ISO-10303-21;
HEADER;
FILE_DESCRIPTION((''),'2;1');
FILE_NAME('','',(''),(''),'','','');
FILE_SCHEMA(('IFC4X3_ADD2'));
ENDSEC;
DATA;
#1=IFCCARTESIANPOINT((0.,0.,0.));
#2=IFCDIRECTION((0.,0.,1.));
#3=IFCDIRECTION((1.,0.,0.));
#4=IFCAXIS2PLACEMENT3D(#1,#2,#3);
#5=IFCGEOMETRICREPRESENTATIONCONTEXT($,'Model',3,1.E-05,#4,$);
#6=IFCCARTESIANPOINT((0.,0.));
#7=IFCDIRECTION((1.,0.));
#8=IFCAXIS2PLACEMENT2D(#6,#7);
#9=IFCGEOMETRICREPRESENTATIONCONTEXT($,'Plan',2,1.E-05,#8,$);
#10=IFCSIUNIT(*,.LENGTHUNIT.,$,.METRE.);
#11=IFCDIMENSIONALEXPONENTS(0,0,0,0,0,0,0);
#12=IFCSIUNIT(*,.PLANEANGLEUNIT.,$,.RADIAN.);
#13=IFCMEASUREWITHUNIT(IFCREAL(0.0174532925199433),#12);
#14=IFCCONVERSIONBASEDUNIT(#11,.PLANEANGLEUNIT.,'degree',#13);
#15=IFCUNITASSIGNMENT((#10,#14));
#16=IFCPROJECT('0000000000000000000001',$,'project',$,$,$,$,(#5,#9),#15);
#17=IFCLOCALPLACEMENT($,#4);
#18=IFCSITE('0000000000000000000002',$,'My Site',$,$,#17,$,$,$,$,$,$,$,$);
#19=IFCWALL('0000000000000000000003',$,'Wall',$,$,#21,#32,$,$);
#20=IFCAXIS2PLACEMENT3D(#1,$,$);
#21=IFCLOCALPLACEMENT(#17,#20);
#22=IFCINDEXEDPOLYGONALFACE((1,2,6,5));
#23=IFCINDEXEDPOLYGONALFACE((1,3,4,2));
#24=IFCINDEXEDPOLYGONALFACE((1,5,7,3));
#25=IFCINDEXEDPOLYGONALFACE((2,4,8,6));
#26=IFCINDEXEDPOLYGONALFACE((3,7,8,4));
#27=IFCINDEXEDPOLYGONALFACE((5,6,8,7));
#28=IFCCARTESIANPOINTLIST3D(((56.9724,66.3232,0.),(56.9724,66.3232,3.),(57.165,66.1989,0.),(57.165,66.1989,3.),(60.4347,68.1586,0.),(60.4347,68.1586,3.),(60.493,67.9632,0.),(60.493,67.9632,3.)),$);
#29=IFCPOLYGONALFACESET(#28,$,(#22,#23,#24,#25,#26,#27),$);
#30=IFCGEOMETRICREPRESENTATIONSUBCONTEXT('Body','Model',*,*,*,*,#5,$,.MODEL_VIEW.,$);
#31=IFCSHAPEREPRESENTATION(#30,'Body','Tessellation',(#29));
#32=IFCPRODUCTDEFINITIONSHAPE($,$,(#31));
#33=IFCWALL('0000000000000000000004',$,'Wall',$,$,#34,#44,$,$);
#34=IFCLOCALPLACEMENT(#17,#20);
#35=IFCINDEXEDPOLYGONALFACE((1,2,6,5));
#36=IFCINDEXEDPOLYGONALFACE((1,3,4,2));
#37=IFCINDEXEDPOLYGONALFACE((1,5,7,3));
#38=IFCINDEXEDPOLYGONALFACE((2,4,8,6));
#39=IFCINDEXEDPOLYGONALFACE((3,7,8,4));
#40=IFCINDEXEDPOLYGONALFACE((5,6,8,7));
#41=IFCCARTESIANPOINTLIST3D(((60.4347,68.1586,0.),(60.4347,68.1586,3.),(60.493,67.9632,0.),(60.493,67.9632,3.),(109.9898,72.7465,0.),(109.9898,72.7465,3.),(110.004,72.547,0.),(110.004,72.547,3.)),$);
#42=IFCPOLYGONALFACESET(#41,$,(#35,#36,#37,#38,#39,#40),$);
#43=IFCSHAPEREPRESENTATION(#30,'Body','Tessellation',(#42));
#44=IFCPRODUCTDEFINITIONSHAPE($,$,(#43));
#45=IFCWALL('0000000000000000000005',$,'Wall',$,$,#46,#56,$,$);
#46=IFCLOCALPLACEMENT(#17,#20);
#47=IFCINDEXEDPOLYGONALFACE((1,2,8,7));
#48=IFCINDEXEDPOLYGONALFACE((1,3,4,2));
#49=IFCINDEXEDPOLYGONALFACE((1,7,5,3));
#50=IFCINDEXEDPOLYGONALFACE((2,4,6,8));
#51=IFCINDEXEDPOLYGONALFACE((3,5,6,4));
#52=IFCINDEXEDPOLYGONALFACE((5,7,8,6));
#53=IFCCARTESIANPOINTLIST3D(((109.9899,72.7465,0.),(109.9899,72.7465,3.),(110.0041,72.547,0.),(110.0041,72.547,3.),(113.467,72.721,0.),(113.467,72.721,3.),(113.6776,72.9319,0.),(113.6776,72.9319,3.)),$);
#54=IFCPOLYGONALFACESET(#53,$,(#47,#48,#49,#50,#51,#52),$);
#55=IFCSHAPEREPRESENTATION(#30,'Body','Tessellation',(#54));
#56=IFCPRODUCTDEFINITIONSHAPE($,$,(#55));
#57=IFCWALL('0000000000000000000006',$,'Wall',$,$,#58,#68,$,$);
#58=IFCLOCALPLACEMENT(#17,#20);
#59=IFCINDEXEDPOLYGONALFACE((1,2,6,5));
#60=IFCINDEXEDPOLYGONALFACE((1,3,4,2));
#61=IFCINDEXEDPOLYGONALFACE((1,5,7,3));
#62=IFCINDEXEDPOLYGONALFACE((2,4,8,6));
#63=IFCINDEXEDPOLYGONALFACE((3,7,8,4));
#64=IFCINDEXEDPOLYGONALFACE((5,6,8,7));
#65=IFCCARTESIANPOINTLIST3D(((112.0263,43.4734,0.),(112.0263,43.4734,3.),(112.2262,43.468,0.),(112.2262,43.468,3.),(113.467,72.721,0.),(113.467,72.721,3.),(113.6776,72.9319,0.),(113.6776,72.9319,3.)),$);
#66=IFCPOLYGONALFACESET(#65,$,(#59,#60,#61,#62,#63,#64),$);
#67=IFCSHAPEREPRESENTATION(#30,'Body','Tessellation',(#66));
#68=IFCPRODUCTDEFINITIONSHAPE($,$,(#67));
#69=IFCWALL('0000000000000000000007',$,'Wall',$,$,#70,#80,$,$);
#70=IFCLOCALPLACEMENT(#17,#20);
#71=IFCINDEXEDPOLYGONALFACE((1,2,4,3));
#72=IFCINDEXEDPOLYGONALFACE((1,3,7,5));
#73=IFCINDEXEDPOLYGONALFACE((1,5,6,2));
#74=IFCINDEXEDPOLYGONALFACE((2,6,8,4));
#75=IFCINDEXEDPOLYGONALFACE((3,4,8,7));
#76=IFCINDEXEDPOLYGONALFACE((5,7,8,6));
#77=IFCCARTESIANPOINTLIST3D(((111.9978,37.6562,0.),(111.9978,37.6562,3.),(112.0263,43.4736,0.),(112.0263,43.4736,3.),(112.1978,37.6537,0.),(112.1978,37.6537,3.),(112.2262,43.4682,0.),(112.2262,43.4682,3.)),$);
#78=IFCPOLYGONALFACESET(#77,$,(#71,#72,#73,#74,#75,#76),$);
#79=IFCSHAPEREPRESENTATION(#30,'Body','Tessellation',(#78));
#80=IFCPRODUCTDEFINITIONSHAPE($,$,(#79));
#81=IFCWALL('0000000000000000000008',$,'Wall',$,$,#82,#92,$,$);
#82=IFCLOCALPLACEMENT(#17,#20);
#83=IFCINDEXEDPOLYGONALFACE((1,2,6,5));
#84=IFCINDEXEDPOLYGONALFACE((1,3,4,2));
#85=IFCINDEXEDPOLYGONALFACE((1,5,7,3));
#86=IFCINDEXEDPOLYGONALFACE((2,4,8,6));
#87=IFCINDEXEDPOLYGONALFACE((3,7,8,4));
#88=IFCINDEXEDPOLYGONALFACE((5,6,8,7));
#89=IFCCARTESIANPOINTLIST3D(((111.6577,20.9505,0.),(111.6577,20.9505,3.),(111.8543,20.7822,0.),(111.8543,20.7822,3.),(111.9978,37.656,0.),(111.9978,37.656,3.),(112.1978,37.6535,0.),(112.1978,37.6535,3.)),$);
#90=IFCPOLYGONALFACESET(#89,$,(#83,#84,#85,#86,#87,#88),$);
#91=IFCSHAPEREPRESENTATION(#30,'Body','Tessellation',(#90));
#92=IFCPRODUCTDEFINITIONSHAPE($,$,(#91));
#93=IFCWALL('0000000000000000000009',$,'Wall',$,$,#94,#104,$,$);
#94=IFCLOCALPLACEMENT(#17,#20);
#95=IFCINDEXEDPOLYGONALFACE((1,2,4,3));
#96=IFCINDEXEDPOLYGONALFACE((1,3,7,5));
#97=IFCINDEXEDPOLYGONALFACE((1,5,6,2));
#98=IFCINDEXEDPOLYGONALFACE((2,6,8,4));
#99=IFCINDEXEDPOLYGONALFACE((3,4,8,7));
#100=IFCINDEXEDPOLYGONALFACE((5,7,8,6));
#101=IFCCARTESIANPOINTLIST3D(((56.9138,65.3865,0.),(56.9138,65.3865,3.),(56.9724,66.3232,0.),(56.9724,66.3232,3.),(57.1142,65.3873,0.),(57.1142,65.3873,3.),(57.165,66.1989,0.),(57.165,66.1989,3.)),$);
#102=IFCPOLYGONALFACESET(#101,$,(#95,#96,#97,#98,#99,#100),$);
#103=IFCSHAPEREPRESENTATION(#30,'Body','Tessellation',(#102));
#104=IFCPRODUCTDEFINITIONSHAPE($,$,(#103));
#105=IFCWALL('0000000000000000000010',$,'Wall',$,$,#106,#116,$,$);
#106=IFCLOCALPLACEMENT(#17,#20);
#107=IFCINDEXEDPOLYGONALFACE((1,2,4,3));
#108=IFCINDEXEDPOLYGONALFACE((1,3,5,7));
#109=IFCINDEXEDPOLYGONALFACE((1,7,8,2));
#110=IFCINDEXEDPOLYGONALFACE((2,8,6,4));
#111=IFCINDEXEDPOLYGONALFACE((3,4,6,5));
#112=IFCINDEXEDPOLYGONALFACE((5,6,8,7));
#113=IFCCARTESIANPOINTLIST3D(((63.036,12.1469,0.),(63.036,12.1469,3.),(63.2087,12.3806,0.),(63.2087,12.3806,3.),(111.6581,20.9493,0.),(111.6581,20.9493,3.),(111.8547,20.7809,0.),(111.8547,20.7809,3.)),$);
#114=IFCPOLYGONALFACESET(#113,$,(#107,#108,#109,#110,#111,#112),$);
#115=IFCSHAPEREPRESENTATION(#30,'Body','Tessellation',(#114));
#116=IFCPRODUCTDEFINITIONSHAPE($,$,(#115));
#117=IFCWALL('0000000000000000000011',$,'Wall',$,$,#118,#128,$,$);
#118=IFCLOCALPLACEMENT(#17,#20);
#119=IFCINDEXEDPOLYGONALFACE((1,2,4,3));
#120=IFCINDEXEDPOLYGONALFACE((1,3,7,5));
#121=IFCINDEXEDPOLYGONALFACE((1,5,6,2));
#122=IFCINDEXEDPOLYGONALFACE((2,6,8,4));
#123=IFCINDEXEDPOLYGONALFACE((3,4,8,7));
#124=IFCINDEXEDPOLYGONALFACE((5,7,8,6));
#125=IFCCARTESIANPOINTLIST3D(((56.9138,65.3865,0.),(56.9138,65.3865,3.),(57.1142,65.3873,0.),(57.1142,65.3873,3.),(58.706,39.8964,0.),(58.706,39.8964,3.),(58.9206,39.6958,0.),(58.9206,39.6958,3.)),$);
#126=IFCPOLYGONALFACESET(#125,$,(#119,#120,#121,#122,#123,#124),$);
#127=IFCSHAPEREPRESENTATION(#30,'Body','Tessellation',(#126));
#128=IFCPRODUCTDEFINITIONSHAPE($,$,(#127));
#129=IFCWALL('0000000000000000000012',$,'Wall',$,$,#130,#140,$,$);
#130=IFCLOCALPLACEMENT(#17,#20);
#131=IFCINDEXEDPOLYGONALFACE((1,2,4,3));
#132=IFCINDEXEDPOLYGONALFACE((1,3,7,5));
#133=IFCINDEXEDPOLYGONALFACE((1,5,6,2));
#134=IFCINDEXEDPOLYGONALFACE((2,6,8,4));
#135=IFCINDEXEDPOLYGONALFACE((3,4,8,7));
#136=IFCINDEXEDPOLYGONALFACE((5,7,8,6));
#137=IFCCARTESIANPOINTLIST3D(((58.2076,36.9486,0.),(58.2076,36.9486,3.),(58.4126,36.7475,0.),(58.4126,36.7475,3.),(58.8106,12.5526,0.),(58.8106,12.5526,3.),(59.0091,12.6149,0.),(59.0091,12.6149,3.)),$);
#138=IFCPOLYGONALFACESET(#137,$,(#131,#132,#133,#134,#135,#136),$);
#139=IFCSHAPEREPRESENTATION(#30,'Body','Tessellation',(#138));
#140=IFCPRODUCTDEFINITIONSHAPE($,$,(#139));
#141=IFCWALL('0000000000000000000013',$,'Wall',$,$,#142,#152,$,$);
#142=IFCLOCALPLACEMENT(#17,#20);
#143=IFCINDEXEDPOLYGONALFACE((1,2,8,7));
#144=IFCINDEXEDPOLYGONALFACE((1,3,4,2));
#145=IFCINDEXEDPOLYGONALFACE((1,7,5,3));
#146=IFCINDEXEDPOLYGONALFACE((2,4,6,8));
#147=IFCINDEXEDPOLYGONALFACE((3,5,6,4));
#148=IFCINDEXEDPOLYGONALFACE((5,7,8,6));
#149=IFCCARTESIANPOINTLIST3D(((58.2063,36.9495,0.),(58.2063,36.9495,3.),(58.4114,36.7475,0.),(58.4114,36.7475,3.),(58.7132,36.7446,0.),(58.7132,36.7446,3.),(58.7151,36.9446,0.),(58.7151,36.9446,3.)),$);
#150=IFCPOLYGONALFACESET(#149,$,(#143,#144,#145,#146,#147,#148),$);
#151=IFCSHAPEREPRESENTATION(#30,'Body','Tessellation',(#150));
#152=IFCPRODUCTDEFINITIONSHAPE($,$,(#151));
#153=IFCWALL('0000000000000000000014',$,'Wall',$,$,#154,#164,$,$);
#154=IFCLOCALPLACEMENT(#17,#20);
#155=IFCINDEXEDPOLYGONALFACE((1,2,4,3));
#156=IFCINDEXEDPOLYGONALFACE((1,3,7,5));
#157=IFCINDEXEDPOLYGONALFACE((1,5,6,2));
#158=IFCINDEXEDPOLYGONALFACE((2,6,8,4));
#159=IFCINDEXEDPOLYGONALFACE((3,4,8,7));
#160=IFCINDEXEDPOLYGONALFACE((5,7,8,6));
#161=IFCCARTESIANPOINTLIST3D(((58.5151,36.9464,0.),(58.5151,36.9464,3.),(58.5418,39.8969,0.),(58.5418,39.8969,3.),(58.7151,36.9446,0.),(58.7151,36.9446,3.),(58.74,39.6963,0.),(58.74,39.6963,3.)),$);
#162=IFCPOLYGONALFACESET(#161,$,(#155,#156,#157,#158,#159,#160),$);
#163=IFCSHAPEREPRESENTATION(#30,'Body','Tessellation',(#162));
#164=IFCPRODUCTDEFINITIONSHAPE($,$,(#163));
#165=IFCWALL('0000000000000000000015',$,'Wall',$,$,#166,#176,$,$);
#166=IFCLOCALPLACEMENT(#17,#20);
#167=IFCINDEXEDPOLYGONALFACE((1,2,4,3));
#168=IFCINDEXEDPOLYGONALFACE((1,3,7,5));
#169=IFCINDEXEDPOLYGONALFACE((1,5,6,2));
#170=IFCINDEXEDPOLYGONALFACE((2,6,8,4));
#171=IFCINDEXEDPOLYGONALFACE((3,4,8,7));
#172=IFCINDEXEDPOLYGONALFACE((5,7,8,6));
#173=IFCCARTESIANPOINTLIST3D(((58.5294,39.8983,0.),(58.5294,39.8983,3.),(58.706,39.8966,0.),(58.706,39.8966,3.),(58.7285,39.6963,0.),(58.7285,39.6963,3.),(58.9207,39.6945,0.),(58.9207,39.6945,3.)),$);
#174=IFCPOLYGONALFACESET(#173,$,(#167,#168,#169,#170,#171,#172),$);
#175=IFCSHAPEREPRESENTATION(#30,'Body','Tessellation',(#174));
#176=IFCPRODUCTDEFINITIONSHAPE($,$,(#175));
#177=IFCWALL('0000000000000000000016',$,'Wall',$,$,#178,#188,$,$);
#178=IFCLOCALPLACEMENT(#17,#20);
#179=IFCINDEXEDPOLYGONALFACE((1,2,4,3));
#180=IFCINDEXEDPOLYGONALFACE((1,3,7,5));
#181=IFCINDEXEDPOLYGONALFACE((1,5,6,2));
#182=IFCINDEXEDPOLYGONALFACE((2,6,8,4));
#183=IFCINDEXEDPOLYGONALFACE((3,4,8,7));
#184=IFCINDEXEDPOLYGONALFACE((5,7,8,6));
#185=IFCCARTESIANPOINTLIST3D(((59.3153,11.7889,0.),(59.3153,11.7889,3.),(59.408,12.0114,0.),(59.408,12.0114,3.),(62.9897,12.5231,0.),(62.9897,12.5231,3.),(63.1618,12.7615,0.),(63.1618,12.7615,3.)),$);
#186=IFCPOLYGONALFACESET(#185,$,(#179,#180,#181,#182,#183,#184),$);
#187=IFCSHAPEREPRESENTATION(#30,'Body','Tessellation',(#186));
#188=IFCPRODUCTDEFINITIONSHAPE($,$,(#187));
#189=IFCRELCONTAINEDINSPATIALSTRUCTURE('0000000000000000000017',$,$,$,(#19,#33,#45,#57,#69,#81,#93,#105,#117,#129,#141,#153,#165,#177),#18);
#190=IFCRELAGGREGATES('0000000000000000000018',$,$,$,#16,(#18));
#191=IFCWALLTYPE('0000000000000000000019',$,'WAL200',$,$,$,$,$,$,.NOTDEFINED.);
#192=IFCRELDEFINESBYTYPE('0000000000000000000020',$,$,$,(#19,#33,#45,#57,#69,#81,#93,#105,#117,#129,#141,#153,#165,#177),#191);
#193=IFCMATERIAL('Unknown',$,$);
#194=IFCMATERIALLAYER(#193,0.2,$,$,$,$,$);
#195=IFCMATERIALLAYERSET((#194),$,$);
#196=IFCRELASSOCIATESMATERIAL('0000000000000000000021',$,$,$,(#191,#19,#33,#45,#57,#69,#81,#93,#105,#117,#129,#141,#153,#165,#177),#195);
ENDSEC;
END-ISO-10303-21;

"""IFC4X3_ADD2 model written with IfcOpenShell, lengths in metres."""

from ifc_helpers import new_model, entity, si_unit, converted_unit, frame, origin_with_axes, origin_2d_with_axis, place, context, subcontext, project, spatial, line, indexed_curve, outline, extrude, material, layer, layer_set, layer_usage, type_object, element, save


model = new_model("IFC4X3_ADD2")

# Units and contexts
model_context = context("Model", 3, precision=1e-05, world=origin_with_axes())
plan_context = context("Plan", 2, precision=1e-05, world=origin_2d_with_axis())
body_context = subcontext(model_context, "Body", "Model", "MODEL_VIEW")
ifc_project = project(units=[si_unit("LENGTHUNIT", "METRE"), converted_unit("PLANEANGLEUNIT", "degree", entity("IfcReal", 0.0174532925199433), si_unit("PLANEANGLEUNIT", "RADIAN"), dimensions=[0, 0, 0, 0, 0, 0, 0])], contexts=[model_context, plan_context])

# Site
site_placement = place(None, origin_with_axes())
site = spatial("IfcSite", under=ifc_project, at=site_placement, Name="My Site")

# Walls
ifc_material = material(Name="Unknown")
ifc_layer = layer(ifc_material, 0.2)
ifc_layer_set = layer_set([ifc_layer])
ifc_layer_usage_1 = layer_usage(ifc_layer_set, "AXIS2", "POSITIVE", 0.0)
wall_type = type_object("IfcWallType", Name="WAL200", PredefinedType="NOTDEFINED", material=ifc_layer_set)
wall_1_placement = place(site_placement, frame((57.165, 66.1989, 0.0), z_axis=(0.0, 0.0, 1.0), x_axis=(0.883526, 0.468382, 0.0)))
element("IfcWall", 1, at=wall_1_placement, inside=site, type_object=wall_type, material=ifc_layer_usage_1, Name="Wall", context=body_context, shape_type="SweptSolid", body=[
    extrude(outline(indexed_curve([(0.0, 0.0), (-0.112, 0.2), (3.8067, 0.2), (3.7666, 0.0)], segments=[line(1, 2, 3, 4, 1)])), origin_with_axes(), (0.0, 0.0, 1.0), 3.0),
])
ifc_layer_usage_2 = layer_usage(ifc_layer_set, "AXIS2", "POSITIVE", 0.0)
wall_2_placement = place(site_placement, frame((60.493, 67.9632, 0.0), z_axis=(0.0, 0.0, 1.0), x_axis=(0.995742, 0.092188, 0.0)))
element("IfcWall", 2, at=wall_2_placement, inside=site, type_object=wall_type, material=ifc_layer_usage_2, Name="Wall", context=body_context, shape_type="SweptSolid", body=[
    extrude(outline(indexed_curve([(0.0, 0.0), (-0.04, 0.2), (49.727, 0.2), (49.7228, 0.0)], segments=[line(1, 2, 3, 4, 1)])), origin_with_axes(), (0.0, 0.0, 1.0), 3.0),
])
ifc_layer_usage_3 = layer_usage(ifc_layer_set, "AXIS2", "POSITIVE", 0.0)
wall_3_placement = place(site_placement, frame((110.0041, 72.547, 0.0), z_axis=(0.0, 0.0, 1.0), x_axis=(0.998739, 0.050195, 0.0)))
element("IfcWall", 3, at=wall_3_placement, inside=site, type_object=wall_type, material=ifc_layer_usage_3, Name="Wall", context=body_context, shape_type="SweptSolid", body=[
    extrude(outline(indexed_curve([(0.0, 0.0), (-0.0042, 0.2), (3.6882, 0.2), (3.4672, 0.0)], segments=[line(1, 2, 3, 4, 1)])), origin_with_axes(), (0.0, 0.0, 1.0), 3.0),
])
ifc_layer_usage_4 = layer_usage(ifc_layer_set, "AXIS2", "POSITIVE", 0.0)
wall_4_placement = place(site_placement, frame((113.467, 72.721, 0.0), z_axis=(0.0, 0.0, 1.0), x_axis=(-0.0492, -0.998789, 0.0)))
element("IfcWall", 4, at=wall_4_placement, inside=site, type_object=wall_type, material=ifc_layer_usage_4, Name="Wall", context=body_context, shape_type="SweptSolid", body=[
    extrude(outline(indexed_curve([(0.0, 0.0), (-0.2209, 0.2), (29.2787, 0.2), (29.2831, 0.0)], segments=[line(1, 2, 3, 4, 1)])), origin_with_axes(), (0.0, 0.0, 1.0), 3.0),
])
ifc_layer_usage_5 = layer_usage(ifc_layer_set, "AXIS2", "POSITIVE", 0.0)
wall_5_placement = place(site_placement, frame((112.0263, 43.4736, 0.0), z_axis=(0.0, 0.0, 1.0), x_axis=(-0.004898, -0.999988, 0.0)))
element("IfcWall", 5, at=wall_5_placement, inside=site, type_object=wall_type, material=ifc_layer_usage_5, Name="Wall", context=body_context, shape_type="SweptSolid", body=[
    extrude(outline(indexed_curve([(0.0, 0.0), (0.0044, 0.2), (5.819, 0.2), (5.8175, 0.0)], segments=[line(1, 2, 3, 4, 1)])), origin_with_axes(), (0.0, 0.0, 1.0), 3.0),
])
ifc_layer_usage_6 = layer_usage(ifc_layer_set, "AXIS2", "POSITIVE", 0.0)
wall_6_placement = place(site_placement, frame((111.9978, 37.656, 0.0), z_axis=(0.0, 0.0, 1.0), x_axis=(-0.020353, -0.999793, 0.0)))
element("IfcWall", 6, at=wall_6_placement, inside=site, type_object=wall_type, material=ifc_layer_usage_6, Name="Wall", context=body_context, shape_type="SweptSolid", body=[
    extrude(outline(indexed_curve([(0.0, 0.0), (-0.0015, 0.2), (16.8733, 0.2), (16.709, 0.0)], segments=[line(1, 2, 3, 4, 1)])), origin_with_axes(), (0.0, 0.0, 1.0), 3.0),
])
ifc_layer_usage_7 = layer_usage(ifc_layer_set, "AXIS2", "POSITIVE", 0.0)
wall_7_placement = place(site_placement, frame((57.1142, 65.3873, 0.0), z_axis=(0.0, 0.0, 1.0), x_axis=(0.062517, 0.998044, 0.0)))
element("IfcWall", 7, at=wall_7_placement, inside=site, type_object=wall_type, material=ifc_layer_usage_7, Name="Wall", context=body_context, shape_type="SweptSolid", body=[
    extrude(outline(indexed_curve([(0.0, 0.0), (-0.0133, 0.2), (0.9252, 0.2), (0.8132, 0.0)], segments=[line(1, 2, 3, 4, 1)])), origin_with_axes(), (0.0, 0.0, 1.0), 3.0),
])
ifc_layer_usage_8 = layer_usage(ifc_layer_set, "AXIS2", "NEGATIVE", 0.0)
wall_8_placement = place(site_placement, frame((63.2087, 12.3806, 0.0), z_axis=(0.0, 0.0, 1.0), x_axis=(0.984718, 0.174156, 0.0)))
element("IfcWall", 8, at=wall_8_placement, inside=site, type_object=wall_type, material=ifc_layer_usage_8, Name="Wall", context=body_context, shape_type="SweptSolid", body=[
    extrude(outline(indexed_curve([(-0.2108, -0.2), (0.0, 0.0), (49.2012, 0.0), (49.3655, -0.2)], segments=[line(1, 2, 3, 4, 1)])), origin_with_axes(), (0.0, 0.0, 1.0), 3.0),
])
ifc_layer_usage_9 = layer_usage(ifc_layer_set, "AXIS2", "POSITIVE", 0.0)
wall_9_placement = place(site_placement, frame((58.9206, 39.6958, 0.0), z_axis=(0.0, 0.0, 1.0), x_axis=(-0.070139, 0.997537, 0.0)))
element("IfcWall", 9, at=wall_9_placement, inside=site, type_object=wall_type, material=ifc_layer_usage_9, Name="Wall", context=body_context, shape_type="SweptSolid", body=[
    extrude(outline(indexed_curve([(0.0, 0.0), (0.2152, 0.2), (25.7682, 0.2), (25.755, 0.0)], segments=[line(1, 2, 3, 4, 1)])), origin_with_axes(), (0.0, 0.0, 1.0), 3.0),
])
ifc_layer_usage_10 = layer_usage(ifc_layer_set, "AXIS2", "POSITIVE", 0.0)
wall_10_placement = place(site_placement, frame((59.0091, 12.6149, 0.0), z_axis=(0.0, 0.0, 1.0), x_axis=(-0.024712, 0.999695, 0.0)))
element("IfcWall", 10, at=wall_10_placement, inside=site, type_object=wall_type, material=ifc_layer_usage_10, Name="Wall", context=body_context, shape_type="SweptSolid", body=[
    extrude(outline(indexed_curve([(0.0, 0.0), (-0.0574, 0.2), (24.346, 0.2), (24.1399, 0.0)], segments=[line(1, 2, 3, 4, 1)])), origin_with_axes(), (0.0, 0.0, 1.0), 3.0),
])
ifc_layer_usage_11 = layer_usage(ifc_layer_set, "AXIS2", "POSITIVE", 0.0)
wall_11_placement = place(site_placement, frame((58.4114, 36.7475, 0.0), z_axis=(0.0, 0.0, 1.0), x_axis=(0.999954, -0.009619, 0.0)))
element("IfcWall", 11, at=wall_11_placement, inside=site, type_object=wall_type, material=ifc_layer_usage_11, Name="Wall", context=body_context, shape_type="SweptSolid", body=[
    extrude(outline(indexed_curve([(0.0, 0.0), (-0.207, 0.2), (0.3018, 0.2), (0.3018, 0.0)], segments=[line(1, 2, 3, 4, 1)])), origin_with_axes(), (0.0, 0.0, 1.0), 3.0),
])
ifc_layer_usage_12 = layer_usage(ifc_layer_set, "AXIS2", "POSITIVE", 0.0)
wall_12_placement = place(site_placement, frame((58.7151, 36.9446, 0.0), z_axis=(0.0, 0.0, 1.0), x_axis=(0.009038, 0.999959, 0.0)))
element("IfcWall", 12, at=wall_12_placement, inside=site, type_object=wall_type, material=ifc_layer_usage_12, Name="Wall", context=body_context, shape_type="SweptSolid", body=[
    extrude(outline(indexed_curve([(0.0, 0.0), (0.0, 0.2), (2.9506, 0.2), (2.7518, 0.0)], segments=[line(1, 2, 3, 4, 1)])), origin_with_axes(), (0.0, 0.0, 1.0), 3.0),
])
ifc_layer_usage_13 = layer_usage(ifc_layer_set, "AXIS2", "POSITIVE", 0.0)
wall_13_placement = place(site_placement, frame((58.7285, 39.6963, 0.0), z_axis=(0.0, 0.0, 1.0), x_axis=(0.999954, -0.009619, 0.0)))
element("IfcWall", 13, at=wall_13_placement, inside=site, type_object=wall_type, material=ifc_layer_usage_13, Name="Wall", context=body_context, shape_type="SweptSolid", body=[
    extrude(outline(indexed_curve([(0.0, 0.0), (-0.201, 0.2), (-0.0244, 0.2), (0.1922, 0.0)], segments=[line(1, 2, 3, 4, 1)])), origin_with_axes(), (0.0, 0.0, 1.0), 3.0),
])
ifc_layer_usage_14 = layer_usage(ifc_layer_set, "AXIS2", "NEGATIVE", 0.0)
wall_14_placement = place(site_placement, frame((59.408, 12.0114, 0.0), z_axis=(0.0, 0.0, 1.0), x_axis=(0.980615, 0.195945, 0.0)))
element("IfcWall", 14, at=wall_14_placement, inside=site, type_object=wall_type, material=ifc_layer_usage_14, Name="Wall", context=body_context, shape_type="SweptSolid", body=[
    extrude(outline(indexed_curve([(-0.1345, -0.2), (0.0, 0.0), (3.828, 0.0), (3.6125, -0.2)], segments=[line(1, 2, 3, 4, 1)])), origin_with_axes(), (0.0, 0.0, 1.0), 3.0),
])

save(model, "model.ifc")
